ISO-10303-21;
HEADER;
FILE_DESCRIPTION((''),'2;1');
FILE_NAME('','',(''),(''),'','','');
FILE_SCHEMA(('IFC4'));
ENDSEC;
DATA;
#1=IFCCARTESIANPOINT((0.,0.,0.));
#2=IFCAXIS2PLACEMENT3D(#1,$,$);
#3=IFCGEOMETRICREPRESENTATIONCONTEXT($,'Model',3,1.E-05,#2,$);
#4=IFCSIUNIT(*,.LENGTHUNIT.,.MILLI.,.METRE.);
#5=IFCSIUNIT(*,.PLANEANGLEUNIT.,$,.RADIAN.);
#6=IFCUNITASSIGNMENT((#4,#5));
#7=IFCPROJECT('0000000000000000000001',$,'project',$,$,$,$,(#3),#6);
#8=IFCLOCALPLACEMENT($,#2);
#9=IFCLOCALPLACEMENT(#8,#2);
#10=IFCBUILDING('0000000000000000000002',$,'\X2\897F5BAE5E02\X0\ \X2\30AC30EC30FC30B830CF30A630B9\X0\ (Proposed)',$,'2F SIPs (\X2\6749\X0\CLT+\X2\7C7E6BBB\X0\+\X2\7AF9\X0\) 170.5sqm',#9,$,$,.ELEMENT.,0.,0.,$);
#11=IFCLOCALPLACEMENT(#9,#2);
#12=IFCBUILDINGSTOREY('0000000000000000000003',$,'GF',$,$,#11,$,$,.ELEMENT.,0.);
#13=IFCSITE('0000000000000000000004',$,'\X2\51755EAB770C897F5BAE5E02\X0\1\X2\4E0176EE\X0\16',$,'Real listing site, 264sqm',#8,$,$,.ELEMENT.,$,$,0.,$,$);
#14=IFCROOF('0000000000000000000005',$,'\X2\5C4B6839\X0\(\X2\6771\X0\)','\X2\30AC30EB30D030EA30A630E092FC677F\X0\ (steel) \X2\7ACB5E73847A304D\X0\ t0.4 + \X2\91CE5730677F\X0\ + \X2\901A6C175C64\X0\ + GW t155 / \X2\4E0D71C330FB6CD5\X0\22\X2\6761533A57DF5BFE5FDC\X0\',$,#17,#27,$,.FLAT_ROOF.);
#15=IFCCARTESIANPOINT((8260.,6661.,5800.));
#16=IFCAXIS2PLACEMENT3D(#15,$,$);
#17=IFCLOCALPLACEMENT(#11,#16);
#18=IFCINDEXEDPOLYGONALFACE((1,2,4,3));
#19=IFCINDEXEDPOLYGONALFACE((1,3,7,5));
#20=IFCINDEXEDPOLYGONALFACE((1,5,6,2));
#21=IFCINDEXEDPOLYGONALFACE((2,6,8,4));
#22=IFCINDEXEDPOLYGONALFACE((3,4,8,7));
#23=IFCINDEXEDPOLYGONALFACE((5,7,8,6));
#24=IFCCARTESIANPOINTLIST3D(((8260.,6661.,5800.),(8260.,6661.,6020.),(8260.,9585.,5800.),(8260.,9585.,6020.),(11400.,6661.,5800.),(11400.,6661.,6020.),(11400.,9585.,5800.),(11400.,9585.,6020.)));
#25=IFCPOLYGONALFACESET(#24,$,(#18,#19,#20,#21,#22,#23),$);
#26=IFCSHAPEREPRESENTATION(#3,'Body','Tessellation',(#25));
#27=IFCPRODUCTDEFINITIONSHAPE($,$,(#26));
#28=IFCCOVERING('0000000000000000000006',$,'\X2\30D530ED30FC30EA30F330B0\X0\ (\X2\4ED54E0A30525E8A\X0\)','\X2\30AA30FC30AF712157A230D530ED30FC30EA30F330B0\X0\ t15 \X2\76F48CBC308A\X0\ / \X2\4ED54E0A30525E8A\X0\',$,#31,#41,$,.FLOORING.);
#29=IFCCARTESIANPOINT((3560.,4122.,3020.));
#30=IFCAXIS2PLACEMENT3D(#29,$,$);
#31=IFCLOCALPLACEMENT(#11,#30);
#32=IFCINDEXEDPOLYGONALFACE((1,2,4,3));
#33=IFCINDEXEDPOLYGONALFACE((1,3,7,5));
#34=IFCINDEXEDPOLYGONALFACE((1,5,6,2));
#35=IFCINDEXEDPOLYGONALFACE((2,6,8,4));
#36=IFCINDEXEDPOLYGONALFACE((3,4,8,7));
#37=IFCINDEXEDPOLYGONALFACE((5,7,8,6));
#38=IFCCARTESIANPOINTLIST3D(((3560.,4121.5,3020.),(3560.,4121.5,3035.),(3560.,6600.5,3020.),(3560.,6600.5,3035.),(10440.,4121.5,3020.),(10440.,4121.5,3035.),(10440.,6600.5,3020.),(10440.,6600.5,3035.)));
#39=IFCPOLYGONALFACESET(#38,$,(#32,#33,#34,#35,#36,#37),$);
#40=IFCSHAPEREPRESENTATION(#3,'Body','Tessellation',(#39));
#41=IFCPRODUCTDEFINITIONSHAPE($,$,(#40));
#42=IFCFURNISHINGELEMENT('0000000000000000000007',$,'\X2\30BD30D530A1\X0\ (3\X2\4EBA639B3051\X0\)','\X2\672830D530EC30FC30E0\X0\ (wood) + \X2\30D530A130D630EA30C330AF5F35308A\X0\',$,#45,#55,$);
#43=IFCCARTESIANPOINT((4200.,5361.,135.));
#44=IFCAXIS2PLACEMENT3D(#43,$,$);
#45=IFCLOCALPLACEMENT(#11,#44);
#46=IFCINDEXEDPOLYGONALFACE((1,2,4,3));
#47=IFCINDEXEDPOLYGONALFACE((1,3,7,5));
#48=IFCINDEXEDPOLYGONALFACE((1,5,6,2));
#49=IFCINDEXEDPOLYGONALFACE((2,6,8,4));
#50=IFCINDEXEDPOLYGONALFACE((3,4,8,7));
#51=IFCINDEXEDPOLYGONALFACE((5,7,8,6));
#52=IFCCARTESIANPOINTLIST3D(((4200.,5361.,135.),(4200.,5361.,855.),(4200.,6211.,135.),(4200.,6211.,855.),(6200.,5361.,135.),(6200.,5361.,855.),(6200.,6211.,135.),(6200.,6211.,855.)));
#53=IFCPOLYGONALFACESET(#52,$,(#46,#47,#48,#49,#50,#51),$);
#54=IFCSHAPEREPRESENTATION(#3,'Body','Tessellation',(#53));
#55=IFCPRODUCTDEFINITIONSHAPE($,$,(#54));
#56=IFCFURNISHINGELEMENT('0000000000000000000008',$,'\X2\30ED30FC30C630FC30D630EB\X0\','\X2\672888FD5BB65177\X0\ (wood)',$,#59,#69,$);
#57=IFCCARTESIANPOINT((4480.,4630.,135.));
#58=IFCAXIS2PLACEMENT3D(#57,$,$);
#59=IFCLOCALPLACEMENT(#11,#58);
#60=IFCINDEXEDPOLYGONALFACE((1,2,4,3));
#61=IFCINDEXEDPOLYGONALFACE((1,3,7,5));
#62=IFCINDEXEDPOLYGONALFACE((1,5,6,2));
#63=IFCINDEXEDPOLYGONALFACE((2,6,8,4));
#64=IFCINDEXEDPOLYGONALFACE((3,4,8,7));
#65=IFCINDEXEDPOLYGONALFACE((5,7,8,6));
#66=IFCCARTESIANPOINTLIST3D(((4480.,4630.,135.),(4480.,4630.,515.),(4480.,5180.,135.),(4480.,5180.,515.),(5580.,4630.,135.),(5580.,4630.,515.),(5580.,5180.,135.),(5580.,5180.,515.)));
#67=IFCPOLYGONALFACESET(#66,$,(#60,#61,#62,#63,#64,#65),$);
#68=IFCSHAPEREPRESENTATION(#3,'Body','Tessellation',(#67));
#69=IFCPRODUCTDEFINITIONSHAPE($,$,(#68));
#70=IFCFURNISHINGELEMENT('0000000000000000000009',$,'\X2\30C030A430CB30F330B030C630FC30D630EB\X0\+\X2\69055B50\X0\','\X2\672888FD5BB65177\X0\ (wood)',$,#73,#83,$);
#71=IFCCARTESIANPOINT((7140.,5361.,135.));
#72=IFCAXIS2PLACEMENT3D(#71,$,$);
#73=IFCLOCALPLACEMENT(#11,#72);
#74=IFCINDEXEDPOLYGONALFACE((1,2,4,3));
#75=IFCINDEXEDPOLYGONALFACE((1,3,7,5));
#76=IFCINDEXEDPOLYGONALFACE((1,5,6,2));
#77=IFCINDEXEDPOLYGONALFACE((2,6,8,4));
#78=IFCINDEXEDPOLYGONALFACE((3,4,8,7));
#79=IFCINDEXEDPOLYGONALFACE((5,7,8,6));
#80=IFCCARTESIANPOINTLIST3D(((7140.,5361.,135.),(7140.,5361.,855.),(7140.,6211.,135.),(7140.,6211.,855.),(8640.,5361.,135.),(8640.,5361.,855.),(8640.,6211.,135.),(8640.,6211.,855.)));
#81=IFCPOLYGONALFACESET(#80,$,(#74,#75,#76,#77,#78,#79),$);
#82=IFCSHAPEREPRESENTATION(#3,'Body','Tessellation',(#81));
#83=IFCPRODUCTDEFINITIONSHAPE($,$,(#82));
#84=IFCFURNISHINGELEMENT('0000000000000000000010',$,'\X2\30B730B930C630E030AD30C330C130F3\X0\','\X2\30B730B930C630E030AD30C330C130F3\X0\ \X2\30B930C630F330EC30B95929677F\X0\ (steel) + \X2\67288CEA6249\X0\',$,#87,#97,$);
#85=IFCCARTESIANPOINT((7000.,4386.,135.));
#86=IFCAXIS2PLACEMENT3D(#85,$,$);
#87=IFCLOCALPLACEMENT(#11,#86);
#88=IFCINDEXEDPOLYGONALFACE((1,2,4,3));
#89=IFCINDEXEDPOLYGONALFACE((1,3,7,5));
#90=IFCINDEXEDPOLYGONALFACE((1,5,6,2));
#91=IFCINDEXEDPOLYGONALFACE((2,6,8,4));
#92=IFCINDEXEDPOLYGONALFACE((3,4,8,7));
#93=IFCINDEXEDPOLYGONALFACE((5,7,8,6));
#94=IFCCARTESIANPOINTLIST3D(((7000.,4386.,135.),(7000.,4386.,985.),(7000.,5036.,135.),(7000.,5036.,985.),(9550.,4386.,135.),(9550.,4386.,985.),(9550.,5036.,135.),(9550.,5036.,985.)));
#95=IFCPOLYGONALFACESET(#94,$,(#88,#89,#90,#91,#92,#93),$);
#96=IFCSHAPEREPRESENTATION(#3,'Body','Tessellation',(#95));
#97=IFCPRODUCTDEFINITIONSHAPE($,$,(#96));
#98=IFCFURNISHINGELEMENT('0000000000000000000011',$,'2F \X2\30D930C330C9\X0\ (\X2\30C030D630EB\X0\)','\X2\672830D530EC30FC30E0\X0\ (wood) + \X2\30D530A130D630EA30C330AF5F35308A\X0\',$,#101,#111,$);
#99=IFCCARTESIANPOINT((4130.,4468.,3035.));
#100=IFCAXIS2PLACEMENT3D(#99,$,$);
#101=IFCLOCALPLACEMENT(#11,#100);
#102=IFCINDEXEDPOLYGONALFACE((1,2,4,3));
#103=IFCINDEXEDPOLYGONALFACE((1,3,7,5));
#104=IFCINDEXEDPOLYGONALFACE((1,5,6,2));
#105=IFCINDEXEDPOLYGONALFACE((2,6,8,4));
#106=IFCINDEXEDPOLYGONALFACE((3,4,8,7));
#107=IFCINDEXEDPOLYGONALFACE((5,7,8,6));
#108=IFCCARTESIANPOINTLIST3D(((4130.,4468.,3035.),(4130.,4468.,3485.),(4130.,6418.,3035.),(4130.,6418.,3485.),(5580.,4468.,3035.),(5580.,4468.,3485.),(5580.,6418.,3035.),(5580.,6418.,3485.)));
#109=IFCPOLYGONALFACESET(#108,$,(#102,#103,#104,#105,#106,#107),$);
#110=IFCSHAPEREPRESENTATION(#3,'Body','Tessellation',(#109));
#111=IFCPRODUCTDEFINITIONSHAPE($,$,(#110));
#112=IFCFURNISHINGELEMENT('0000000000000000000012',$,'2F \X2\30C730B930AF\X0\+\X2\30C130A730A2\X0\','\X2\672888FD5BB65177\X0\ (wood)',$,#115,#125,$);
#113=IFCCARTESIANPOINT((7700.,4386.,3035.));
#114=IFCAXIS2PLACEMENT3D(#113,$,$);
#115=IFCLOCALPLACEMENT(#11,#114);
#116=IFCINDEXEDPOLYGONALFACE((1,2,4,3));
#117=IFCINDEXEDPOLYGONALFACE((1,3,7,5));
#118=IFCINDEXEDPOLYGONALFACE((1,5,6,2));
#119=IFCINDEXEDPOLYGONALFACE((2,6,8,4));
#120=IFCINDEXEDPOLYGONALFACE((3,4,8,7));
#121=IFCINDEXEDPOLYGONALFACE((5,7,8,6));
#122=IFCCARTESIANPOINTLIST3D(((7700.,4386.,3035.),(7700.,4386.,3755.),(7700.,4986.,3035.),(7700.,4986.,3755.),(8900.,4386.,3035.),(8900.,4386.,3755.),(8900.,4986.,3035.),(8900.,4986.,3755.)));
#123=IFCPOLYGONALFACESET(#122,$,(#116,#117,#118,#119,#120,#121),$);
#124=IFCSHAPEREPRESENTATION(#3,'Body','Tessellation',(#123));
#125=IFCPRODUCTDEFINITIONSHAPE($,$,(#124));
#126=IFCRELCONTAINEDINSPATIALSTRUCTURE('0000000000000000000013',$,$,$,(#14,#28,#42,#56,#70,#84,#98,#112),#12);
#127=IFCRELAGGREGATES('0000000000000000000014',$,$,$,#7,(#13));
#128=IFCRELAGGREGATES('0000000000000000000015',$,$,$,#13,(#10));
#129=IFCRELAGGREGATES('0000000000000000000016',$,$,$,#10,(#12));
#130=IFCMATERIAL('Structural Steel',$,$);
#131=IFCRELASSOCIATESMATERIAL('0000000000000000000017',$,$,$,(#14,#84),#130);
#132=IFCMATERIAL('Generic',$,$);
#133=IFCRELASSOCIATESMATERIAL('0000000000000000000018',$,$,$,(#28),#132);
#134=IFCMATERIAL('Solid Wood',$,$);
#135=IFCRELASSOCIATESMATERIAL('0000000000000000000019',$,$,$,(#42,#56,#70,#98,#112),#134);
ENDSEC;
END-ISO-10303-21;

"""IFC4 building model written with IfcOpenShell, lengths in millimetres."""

from ifc_helpers import new_model, si_unit, frame, frame_2d, origin, place, context, project, spatial, rectangle, extrude, material, element, save


model = new_model("IFC4")

# Units and contexts
model_context = context("Model", 3, precision=1e-05, world=origin())
ifc_project = project(units=[si_unit("LENGTHUNIT", "METRE", prefix="MILLI"), si_unit("PLANEANGLEUNIT", "RADIAN")], contexts=[model_context])

# Site, building, storey
site_placement = place(None, origin())
site = spatial("IfcSite", under=ifc_project, at=site_placement, Name="兵庫県西宮市1丁目16", ObjectType="Real listing site, 264sqm", CompositionType="ELEMENT", RefElevation=0.0)
building_placement = place(site_placement, origin())
building = spatial("IfcBuilding", under=site, at=building_placement, Name="西宮市 ガレージハウス (Proposed)", ObjectType="2F SIPs (杉CLT+籾殻+竹) 170.5sqm", CompositionType="ELEMENT", ElevationOfRefHeight=0.0, ElevationOfTerrain=0.0)
storey_placement = place(building_placement, origin())
storey = spatial("IfcBuildingStorey", under=building, at=storey_placement, Name="GF", CompositionType="ELEMENT", Elevation=0.0)

# Shared definitions
ifc_material_1 = material(Name="Solid Wood")

# Shared definitions
ifc_material_2 = material(Name="Generic")

# Roof
ifc_material_3 = material(Name="Structural Steel")
roof_placement = place(storey_placement, frame((8260.0, 6661.0, 5800.0)))
element("IfcRoof", 1, at=roof_placement, inside=storey, material=ifc_material_3, Name="屋根(東)", Description="ガルバリウム鋼板 (steel) 立平葺き t0.4 + 野地板 + 通気層 + GW t155 / 不燃・法22条区域対応", PredefinedType="FLAT_ROOF", context=model_context, shape_type="SweptSolid", body=[
    extrude(rectangle(XDim=3140.0, YDim=2924.0, at=frame_2d((1570.0, 1462.0))), frame((8260.0, 6661.0, 5800.0)), (0.0, 0.0, 1.0), 220.0),
])

# Covering
covering_placement = place(storey_placement, frame((3560.0, 4122.0, 3020.0)))
element("IfcCovering", 2, at=covering_placement, inside=storey, material=ifc_material_2, Name="フローリング (仕上げ床)", Description="オーク無垢フローリング t15 直貼り / 仕上げ床", PredefinedType="FLOORING", context=model_context, shape_type="SweptSolid", body=[
    extrude(rectangle(XDim=6880.0, YDim=2479.0, at=frame_2d((3440.0, 1239.0))), frame((3560.0, 4122.0, 3020.0)), (0.0, 0.0, 1.0), 15.0),
])

# Furnishing elements
furnishing_1_placement = place(storey_placement, frame((4200.0, 5361.0, 135.0)))
element("IfcFurnishingElement", 3, at=furnishing_1_placement, inside=storey, material=ifc_material_1, Name="ソファ (3人掛け)", Description="木フレーム (wood) + ファブリック張り", context=model_context, shape_type="SweptSolid", body=[
    extrude(rectangle(XDim=2000.0, YDim=850.0, at=frame_2d((1000.0, 425.0))), frame((4200.0, 5361.0, 135.0)), (0.0, 0.0, 1.0), 720.0),
])
furnishing_2_placement = place(storey_placement, frame((4480.0, 4630.0, 135.0)))
element("IfcFurnishingElement", 4, at=furnishing_2_placement, inside=storey, material=ifc_material_1, Name="ローテーブル", Description="木製家具 (wood)", context=model_context, shape_type="SweptSolid", body=[
    extrude(rectangle(XDim=1100.0, YDim=550.0, at=frame_2d((550.0, 275.0))), frame((4480.0, 4630.0, 135.0)), (0.0, 0.0, 1.0), 380.0),
])
furnishing_3_placement = place(storey_placement, frame((7140.0, 5361.0, 135.0)))
element("IfcFurnishingElement", 5, at=furnishing_3_placement, inside=storey, material=ifc_material_1, Name="ダイニングテーブル+椅子", Description="木製家具 (wood)", context=model_context, shape_type="SweptSolid", body=[
    extrude(rectangle(XDim=1500.0, YDim=850.0, at=frame_2d((750.0, 425.0))), frame((7140.0, 5361.0, 135.0)), (0.0, 0.0, 1.0), 720.0),
])
furnishing_4_placement = place(storey_placement, frame((7000.0, 4386.0, 135.0)))
element("IfcFurnishingElement", 6, at=furnishing_4_placement, inside=storey, material=ifc_material_3, Name="システムキッチン", Description="システムキッチン ステンレス天板 (steel) + 木質扉", context=model_context, shape_type="SweptSolid", body=[
    extrude(rectangle(XDim=2550.0, YDim=650.0, at=frame_2d((1275.0, 325.0))), frame((7000.0, 4386.0, 135.0)), (0.0, 0.0, 1.0), 850.0),
])
furnishing_5_placement = place(storey_placement, frame((4130.0, 4468.0, 3035.0)))
element("IfcFurnishingElement", 7, at=furnishing_5_placement, inside=storey, material=ifc_material_1, Name="2F ベッド (ダブル)", Description="木フレーム (wood) + ファブリック張り", context=model_context, shape_type="SweptSolid", body=[
    extrude(rectangle(XDim=1450.0, YDim=1950.0, at=frame_2d((725.0, 975.0))), frame((4130.0, 4468.0, 3035.0)), (0.0, 0.0, 1.0), 450.0),
])
furnishing_6_placement = place(storey_placement, frame((7700.0, 4386.0, 3035.0)))
element("IfcFurnishingElement", 8, at=furnishing_6_placement, inside=storey, material=ifc_material_1, Name="2F デスク+チェア", Description="木製家具 (wood)", context=model_context, shape_type="SweptSolid", body=[
    extrude(rectangle(XDim=1200.0, YDim=600.0, at=frame_2d((600.0, 300.0))), frame((7700.0, 4386.0, 3035.0)), (0.0, 0.0, 1.0), 720.0),
])

save(model, "model.ifc")
